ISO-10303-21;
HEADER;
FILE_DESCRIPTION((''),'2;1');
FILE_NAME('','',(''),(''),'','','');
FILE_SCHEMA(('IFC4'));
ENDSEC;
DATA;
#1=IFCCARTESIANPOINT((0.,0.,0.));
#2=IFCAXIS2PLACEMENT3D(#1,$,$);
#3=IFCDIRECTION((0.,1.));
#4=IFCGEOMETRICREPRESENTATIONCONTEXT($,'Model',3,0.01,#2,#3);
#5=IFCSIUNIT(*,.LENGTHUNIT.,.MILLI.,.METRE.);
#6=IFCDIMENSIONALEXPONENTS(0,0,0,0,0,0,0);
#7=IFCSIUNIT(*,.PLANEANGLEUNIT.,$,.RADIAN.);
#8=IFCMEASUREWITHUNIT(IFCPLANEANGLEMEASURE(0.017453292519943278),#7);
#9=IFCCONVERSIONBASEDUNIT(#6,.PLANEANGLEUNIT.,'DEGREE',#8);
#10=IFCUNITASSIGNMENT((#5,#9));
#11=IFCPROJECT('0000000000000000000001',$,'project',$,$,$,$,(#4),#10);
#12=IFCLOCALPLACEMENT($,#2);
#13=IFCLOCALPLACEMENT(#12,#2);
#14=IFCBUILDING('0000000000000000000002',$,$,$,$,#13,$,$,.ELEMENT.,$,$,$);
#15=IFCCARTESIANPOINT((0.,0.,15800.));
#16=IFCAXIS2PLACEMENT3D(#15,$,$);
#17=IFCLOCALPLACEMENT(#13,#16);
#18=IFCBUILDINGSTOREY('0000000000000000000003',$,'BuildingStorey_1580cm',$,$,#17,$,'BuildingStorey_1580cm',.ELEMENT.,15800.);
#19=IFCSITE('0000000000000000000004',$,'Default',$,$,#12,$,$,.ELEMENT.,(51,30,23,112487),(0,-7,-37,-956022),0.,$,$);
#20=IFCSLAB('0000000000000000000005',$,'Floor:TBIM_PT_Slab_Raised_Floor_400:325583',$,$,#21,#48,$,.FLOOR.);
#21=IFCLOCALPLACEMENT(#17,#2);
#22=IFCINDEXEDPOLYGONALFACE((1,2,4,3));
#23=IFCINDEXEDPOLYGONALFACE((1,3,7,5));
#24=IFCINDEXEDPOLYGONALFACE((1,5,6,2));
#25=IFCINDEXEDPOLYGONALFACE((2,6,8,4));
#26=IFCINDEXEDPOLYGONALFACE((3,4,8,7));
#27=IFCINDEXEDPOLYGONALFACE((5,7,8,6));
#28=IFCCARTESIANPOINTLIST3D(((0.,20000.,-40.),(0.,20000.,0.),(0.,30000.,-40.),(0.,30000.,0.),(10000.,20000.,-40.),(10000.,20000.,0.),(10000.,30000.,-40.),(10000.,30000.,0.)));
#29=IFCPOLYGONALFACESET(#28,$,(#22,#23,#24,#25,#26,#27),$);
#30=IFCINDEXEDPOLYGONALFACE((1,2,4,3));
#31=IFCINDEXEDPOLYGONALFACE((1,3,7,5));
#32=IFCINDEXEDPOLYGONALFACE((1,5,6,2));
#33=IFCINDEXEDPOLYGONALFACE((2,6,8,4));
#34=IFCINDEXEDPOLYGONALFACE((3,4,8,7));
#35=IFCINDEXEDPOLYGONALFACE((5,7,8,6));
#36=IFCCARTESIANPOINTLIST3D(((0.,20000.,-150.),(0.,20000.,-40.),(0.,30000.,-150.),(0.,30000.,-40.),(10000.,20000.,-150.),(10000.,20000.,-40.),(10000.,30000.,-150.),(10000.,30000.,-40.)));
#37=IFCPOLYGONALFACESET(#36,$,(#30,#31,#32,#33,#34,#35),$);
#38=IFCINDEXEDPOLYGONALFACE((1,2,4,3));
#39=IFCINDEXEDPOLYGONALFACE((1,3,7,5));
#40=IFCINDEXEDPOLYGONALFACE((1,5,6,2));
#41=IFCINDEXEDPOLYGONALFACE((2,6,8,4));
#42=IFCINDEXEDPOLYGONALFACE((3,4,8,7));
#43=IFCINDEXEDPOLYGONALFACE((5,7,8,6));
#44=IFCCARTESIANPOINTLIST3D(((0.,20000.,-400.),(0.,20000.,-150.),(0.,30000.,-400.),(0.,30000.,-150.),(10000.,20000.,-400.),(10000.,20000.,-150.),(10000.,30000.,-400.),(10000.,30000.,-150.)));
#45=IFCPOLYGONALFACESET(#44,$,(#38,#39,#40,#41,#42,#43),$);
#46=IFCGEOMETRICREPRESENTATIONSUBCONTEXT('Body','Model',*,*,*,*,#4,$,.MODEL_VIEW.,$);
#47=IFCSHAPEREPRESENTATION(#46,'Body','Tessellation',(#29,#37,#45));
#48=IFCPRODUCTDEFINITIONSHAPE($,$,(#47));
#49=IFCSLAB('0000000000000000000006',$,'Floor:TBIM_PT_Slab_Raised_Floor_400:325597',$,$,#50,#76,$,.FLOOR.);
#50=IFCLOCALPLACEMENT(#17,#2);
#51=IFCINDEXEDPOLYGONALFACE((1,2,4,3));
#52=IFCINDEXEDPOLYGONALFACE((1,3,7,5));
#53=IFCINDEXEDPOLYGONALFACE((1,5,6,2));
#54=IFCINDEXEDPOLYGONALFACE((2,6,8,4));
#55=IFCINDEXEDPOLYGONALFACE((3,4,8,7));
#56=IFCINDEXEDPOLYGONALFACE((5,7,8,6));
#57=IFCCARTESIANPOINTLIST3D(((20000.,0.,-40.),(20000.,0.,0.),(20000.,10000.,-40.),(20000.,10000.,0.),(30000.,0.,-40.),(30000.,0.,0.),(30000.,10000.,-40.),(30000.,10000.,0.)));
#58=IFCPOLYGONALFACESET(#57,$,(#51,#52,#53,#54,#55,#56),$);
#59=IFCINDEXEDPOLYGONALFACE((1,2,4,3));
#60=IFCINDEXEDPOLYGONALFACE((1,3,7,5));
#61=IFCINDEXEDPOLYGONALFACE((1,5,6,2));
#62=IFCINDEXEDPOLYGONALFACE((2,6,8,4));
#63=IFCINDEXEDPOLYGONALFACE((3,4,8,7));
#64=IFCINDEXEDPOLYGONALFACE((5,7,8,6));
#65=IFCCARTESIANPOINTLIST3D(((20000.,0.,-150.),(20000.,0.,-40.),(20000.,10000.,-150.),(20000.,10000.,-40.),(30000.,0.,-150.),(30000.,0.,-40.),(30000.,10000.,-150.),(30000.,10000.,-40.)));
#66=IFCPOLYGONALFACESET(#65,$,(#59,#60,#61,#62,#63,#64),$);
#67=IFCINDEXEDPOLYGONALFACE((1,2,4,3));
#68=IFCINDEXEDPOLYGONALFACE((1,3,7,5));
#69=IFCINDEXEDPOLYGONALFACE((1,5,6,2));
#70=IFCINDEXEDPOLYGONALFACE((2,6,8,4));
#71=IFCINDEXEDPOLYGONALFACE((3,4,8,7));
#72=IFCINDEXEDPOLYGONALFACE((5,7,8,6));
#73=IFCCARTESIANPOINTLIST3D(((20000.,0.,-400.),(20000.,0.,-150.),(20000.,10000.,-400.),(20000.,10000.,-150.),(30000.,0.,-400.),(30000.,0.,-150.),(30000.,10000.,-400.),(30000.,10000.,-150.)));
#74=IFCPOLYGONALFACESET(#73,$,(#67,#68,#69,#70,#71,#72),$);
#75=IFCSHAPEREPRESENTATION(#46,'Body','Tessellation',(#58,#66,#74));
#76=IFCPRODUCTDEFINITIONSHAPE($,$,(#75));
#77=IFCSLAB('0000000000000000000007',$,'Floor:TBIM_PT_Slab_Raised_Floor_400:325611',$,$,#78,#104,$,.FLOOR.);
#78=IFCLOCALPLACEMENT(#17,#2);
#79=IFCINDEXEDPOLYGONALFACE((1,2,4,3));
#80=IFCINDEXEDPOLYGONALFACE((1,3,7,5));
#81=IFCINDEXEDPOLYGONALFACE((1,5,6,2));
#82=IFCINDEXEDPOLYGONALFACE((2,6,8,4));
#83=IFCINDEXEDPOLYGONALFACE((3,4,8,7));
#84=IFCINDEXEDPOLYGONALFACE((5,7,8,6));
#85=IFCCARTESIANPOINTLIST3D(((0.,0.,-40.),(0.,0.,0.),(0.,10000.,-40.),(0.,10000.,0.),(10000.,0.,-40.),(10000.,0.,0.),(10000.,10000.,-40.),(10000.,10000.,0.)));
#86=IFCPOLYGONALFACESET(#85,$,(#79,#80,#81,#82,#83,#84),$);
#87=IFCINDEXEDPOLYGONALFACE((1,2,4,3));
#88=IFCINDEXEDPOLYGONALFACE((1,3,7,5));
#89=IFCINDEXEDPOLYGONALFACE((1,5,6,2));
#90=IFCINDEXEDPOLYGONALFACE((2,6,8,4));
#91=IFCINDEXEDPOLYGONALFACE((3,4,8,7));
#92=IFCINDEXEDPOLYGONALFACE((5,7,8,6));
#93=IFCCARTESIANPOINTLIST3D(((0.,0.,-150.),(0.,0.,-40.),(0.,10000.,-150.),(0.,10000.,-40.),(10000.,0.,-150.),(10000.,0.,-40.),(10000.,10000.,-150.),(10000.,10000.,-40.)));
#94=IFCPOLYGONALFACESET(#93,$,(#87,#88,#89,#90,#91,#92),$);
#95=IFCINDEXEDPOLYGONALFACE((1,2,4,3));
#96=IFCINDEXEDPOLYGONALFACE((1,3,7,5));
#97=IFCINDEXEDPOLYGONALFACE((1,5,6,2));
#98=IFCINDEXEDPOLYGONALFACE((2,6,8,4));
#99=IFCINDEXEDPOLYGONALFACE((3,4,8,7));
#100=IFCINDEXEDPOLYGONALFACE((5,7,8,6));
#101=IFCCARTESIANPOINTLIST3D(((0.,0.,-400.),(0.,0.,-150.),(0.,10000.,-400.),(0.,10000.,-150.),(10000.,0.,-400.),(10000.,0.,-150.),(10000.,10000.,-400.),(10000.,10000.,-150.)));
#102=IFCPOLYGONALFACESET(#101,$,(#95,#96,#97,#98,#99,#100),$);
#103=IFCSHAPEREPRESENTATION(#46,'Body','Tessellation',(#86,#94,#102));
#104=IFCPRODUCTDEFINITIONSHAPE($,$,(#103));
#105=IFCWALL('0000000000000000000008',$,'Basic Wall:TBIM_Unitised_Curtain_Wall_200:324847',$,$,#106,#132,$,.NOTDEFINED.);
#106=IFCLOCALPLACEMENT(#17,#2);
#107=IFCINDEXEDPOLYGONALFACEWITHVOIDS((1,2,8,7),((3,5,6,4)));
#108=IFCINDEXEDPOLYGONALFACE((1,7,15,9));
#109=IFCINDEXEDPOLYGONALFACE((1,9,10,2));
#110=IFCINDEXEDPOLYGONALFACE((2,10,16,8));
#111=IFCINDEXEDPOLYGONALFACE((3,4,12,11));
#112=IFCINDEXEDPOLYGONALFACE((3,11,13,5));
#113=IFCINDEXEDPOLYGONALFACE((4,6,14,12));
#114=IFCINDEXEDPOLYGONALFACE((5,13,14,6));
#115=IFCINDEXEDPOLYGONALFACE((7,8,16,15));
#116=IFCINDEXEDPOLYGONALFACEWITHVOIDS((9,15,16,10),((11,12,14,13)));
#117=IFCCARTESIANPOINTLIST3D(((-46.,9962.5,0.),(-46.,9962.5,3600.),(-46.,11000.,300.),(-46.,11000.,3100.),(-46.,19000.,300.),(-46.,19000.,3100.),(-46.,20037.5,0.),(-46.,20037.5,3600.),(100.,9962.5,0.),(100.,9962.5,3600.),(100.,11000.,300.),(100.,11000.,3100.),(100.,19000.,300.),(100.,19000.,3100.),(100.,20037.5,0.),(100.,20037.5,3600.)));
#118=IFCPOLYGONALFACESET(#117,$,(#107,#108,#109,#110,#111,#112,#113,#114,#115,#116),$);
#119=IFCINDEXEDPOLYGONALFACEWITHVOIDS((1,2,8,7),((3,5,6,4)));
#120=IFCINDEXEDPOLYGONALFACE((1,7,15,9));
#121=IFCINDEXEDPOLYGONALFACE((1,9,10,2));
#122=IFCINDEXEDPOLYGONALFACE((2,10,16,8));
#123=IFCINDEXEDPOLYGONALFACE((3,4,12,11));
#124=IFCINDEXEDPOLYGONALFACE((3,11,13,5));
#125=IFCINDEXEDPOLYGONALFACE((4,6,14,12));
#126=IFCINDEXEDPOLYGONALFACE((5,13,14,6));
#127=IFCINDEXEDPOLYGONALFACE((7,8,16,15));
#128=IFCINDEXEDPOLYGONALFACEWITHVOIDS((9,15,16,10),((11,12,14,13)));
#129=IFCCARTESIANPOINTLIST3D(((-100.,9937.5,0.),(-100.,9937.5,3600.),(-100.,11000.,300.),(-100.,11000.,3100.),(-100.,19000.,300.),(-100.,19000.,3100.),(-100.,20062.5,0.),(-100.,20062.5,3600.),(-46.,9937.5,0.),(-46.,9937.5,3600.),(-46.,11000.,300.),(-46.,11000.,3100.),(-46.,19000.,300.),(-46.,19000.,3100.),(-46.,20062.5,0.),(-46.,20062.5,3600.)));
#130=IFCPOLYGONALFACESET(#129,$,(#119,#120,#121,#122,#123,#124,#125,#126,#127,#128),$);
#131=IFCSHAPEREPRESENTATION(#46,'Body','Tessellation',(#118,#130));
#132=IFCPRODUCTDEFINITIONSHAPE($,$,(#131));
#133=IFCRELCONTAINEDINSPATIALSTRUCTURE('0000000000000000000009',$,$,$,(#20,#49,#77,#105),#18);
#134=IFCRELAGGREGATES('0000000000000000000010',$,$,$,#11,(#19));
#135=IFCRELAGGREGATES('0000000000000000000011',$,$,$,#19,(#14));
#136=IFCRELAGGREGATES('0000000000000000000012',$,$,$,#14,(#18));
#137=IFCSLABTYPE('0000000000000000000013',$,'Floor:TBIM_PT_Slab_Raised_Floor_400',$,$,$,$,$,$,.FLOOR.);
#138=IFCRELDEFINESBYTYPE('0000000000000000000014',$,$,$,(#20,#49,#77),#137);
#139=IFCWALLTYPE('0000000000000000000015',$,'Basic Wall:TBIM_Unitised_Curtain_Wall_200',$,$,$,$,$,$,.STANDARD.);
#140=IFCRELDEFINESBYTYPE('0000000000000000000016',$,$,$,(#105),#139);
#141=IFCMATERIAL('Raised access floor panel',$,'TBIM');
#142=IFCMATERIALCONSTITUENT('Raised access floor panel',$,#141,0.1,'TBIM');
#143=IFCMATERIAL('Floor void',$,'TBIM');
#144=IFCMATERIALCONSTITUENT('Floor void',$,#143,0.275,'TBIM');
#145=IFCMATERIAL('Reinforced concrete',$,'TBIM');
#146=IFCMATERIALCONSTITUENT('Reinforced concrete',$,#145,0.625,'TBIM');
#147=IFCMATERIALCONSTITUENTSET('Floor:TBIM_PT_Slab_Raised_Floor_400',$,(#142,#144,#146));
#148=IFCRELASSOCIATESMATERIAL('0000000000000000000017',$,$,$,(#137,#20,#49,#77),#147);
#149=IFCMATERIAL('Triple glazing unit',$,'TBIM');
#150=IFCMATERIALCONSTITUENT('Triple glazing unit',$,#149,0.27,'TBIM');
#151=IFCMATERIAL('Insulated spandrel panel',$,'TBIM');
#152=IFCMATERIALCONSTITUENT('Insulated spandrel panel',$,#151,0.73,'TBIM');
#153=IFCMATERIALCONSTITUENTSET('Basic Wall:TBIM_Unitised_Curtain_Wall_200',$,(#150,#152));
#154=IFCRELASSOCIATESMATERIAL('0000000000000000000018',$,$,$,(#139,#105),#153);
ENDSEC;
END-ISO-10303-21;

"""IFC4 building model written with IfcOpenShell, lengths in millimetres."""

from ifc_helpers import new_model, entity, si_unit, converted_unit, direction, frame, origin, place, context, subcontext, project, spatial, indexed_curve, outline, extrude, material, constituent, constituent_set, type_object, element, save


model = new_model("IFC4")

# Units and contexts
model_context = context("Model", 3, precision=0.01, world=origin(), true_north=direction((0.0, 1.0)))
body_context = subcontext(model_context, "Body", "Model", "MODEL_VIEW")
ifc_project = project(units=[si_unit("LENGTHUNIT", "METRE", prefix="MILLI"), converted_unit("PLANEANGLEUNIT", "DEGREE", entity("IfcPlaneAngleMeasure", 0.017453292519943278), si_unit("PLANEANGLEUNIT", "RADIAN"), dimensions=[0, 0, 0, 0, 0, 0, 0])], contexts=[model_context])

# Site, building, storey
site_placement = place(None, origin())
site = spatial("IfcSite", under=ifc_project, at=site_placement, Name="Default", CompositionType="ELEMENT", RefLatitude=(51, 30, 23, 112487), RefLongitude=(0, -7, -37, -956022), RefElevation=0.0)
building_placement = place(site_placement, origin())
building = spatial("IfcBuilding", under=site, at=building_placement, CompositionType="ELEMENT")
storey_placement = place(building_placement, frame((0.0, 0.0, 15800.0)))
storey = spatial("IfcBuildingStorey", under=building, at=storey_placement, Name="BuildingStorey_1580cm", LongName="BuildingStorey_1580cm", CompositionType="ELEMENT", Elevation=15800.0)

# Slabs
ifc_material_1 = material(Name="Raised access floor panel", Category="TBIM")
ifc_constituent_1 = constituent(ifc_material_1, Name="Raised access floor panel", Category="TBIM", fraction=0.1)
ifc_material_2 = material(Name="Floor void", Category="TBIM")
ifc_constituent_2 = constituent(ifc_material_2, Name="Floor void", Category="TBIM", fraction=0.275)
ifc_material_3 = material(Name="Reinforced concrete", Category="TBIM")
ifc_constituent_3 = constituent(ifc_material_3, Name="Reinforced concrete", Category="TBIM", fraction=0.625)
ifc_constituent_set_1 = constituent_set(constituents=[ifc_constituent_1, ifc_constituent_2, ifc_constituent_3], Name="Floor:TBIM_PT_Slab_Raised_Floor_400")
slab_type = type_object("IfcSlabType", Name="Floor:TBIM_PT_Slab_Raised_Floor_400", PredefinedType="FLOOR", material=ifc_constituent_set_1)
slab_1_placement = place(storey_placement, origin())
element("IfcSlab", 1, at=slab_1_placement, inside=storey, type_object=slab_type, material=ifc_constituent_set_1, Name="Floor:TBIM_PT_Slab_Raised_Floor_400:325583", PredefinedType="FLOOR", context=body_context, shape_type="SweptSolid", body=[
    extrude(outline(indexed_curve([(-5000.0, -5000.0), (5000.0, -5000.0), (5000.0, 5000.0), (-5000.0, 5000.0), (-5000.0, -5000.0)], self_intersect=False)), frame((5000.0, 25000.0, -40.0), z_axis=(0.0, 0.0, 1.0), x_axis=(-1.0, 0.0, 0.0)), (0.0, 0.0, 1.0), 40.0),
    extrude(outline(indexed_curve([(-5000.0, -5000.0), (5000.0, -5000.0), (5000.0, 5000.0), (-5000.0, 5000.0), (-5000.0, -5000.0)], self_intersect=False)), frame((5000.0, 25000.0, -150.0), z_axis=(0.0, 0.0, 1.0), x_axis=(-1.0, 0.0, 0.0)), (0.0, 0.0, 1.0), 110.0),
    extrude(outline(indexed_curve([(-5000.0, -5000.0), (5000.0, -5000.0), (5000.0, 5000.0), (-5000.0, 5000.0), (-5000.0, -5000.0)], self_intersect=False)), frame((5000.0, 25000.0, -400.0), z_axis=(0.0, 0.0, 1.0), x_axis=(-1.0, 0.0, 0.0)), (0.0, 0.0, 1.0), 250.0),
])
slab_2_placement = place(storey_placement, origin())
element("IfcSlab", 2, at=slab_2_placement, inside=storey, type_object=slab_type, material=ifc_constituent_set_1, Name="Floor:TBIM_PT_Slab_Raised_Floor_400:325597", PredefinedType="FLOOR", context=body_context, shape_type="SweptSolid", body=[
    extrude(outline(indexed_curve([(-5000.0, -5000.0), (5000.0, -5000.0), (5000.0, 5000.0), (-5000.0, 5000.0), (-5000.0, -5000.0)], self_intersect=False)), frame((25000.0, 5000.0, -40.0), z_axis=(0.0, 0.0, 1.0), x_axis=(-1.0, 0.0, 0.0)), (0.0, 0.0, 1.0), 40.0),
    extrude(outline(indexed_curve([(-5000.0, -5000.0), (5000.0, -5000.0), (5000.0, 5000.0), (-5000.0, 5000.0), (-5000.0, -5000.0)], self_intersect=False)), frame((25000.0, 5000.0, -150.0), z_axis=(0.0, 0.0, 1.0), x_axis=(-1.0, 0.0, 0.0)), (0.0, 0.0, 1.0), 110.0),
    extrude(outline(indexed_curve([(-5000.0, -5000.0), (5000.0, -5000.0), (5000.0, 5000.0), (-5000.0, 5000.0), (-5000.0, -5000.0)], self_intersect=False)), frame((25000.0, 5000.0, -400.0), z_axis=(0.0, 0.0, 1.0), x_axis=(-1.0, 0.0, 0.0)), (0.0, 0.0, 1.0), 250.0),
])
slab_3_placement = place(storey_placement, origin())
element("IfcSlab", 3, at=slab_3_placement, inside=storey, type_object=slab_type, material=ifc_constituent_set_1, Name="Floor:TBIM_PT_Slab_Raised_Floor_400:325611", PredefinedType="FLOOR", context=body_context, shape_type="SweptSolid", body=[
    extrude(outline(indexed_curve([(-5000.0, -5000.0), (5000.0, -5000.0), (5000.0, 5000.0), (-5000.0, 5000.0), (-5000.0, -5000.0)], self_intersect=False)), frame((5000.0, 5000.0, -40.0), z_axis=(0.0, 0.0, 1.0), x_axis=(-1.0, 0.0, 0.0)), (0.0, 0.0, 1.0), 40.0),
    extrude(outline(indexed_curve([(-5000.0, -5000.0), (5000.0, -5000.0), (5000.0, 5000.0), (-5000.0, 5000.0), (-5000.0, -5000.0)], self_intersect=False)), frame((5000.0, 5000.0, -150.0), z_axis=(0.0, 0.0, 1.0), x_axis=(-1.0, 0.0, 0.0)), (0.0, 0.0, 1.0), 110.0),
    extrude(outline(indexed_curve([(-5000.0, -5000.0), (5000.0, -5000.0), (5000.0, 5000.0), (-5000.0, 5000.0), (-5000.0, -5000.0)], self_intersect=False)), frame((5000.0, 5000.0, -400.0), z_axis=(0.0, 0.0, 1.0), x_axis=(-1.0, 0.0, 0.0)), (0.0, 0.0, 1.0), 250.0),
])

# Wall, opening
ifc_material_4 = material(Name="Triple glazing unit", Category="TBIM")
ifc_constituent_4 = constituent(ifc_material_4, Name="Triple glazing unit", Category="TBIM", fraction=0.27)
ifc_material_5 = material(Name="Insulated spandrel panel", Category="TBIM")
ifc_constituent_5 = constituent(ifc_material_5, Name="Insulated spandrel panel", Category="TBIM", fraction=0.73)
ifc_constituent_set_2 = constituent_set(constituents=[ifc_constituent_4, ifc_constituent_5], Name="Basic Wall:TBIM_Unitised_Curtain_Wall_200")
wall_type = type_object("IfcWallType", Name="Basic Wall:TBIM_Unitised_Curtain_Wall_200", PredefinedType="STANDARD", material=ifc_constituent_set_2)
wall_1_placement = place(storey_placement, frame((0.0, 9937.5, 0.0), z_axis=(0.0, 0.0, 1.0), x_axis=(0.0, 1.0, 0.0)))
wall_1 = element("IfcWall", 4, at=wall_1_placement, inside=storey, type_object=wall_type, material=ifc_constituent_set_2, Name="Basic Wall:TBIM_Unitised_Curtain_Wall_200:324847", PredefinedType="NOTDEFINED", context=body_context, shape_type="SweptSolid", body=[
    extrude(outline(indexed_curve([(-1800.0, -5037.5), (1800.0, -5037.5), (1800.0, 5037.5), (-1800.0, 5037.5), (-1800.0, -5037.5)], self_intersect=False), holes=[indexed_curve([(1300.0, 4000.0), (1300.0, -4000.0), (-1500.0, -4000.0), (-1500.0, 4000.0), (1300.0, 4000.0)], self_intersect=False)]), frame((5062.5, 46.0, 1800.0), z_axis=(0.0, -1.0, 0.0), x_axis=(0.0, 0.0, 1.0)), (0.0, 0.0, 1.0), 146.0),
    extrude(outline(indexed_curve([(-5062.5, -1800.0), (5062.5, -1800.0), (5062.5, 1800.0), (-5062.5, 1800.0), (-5062.5, -1800.0)], self_intersect=False), holes=[indexed_curve([(-4000.0, 1300.0), (4000.0, 1300.0), (4000.0, -1500.0), (-4000.0, -1500.0), (-4000.0, 1300.0)], self_intersect=False)]), frame((5062.5, 100.0, 1800.0), z_axis=(0.0, -1.0, 0.0), x_axis=(1.0, 0.0, 0.0)), (0.0, 0.0, 1.0), 54.0),
])
opening_1_placement = place(wall_1_placement, frame((1062.5, -100.0, 300.0)))
element("IfcOpeningElement", 5, at=opening_1_placement, cuts=wall_1, PredefinedType="OPENING", context=body_context, shape_type="SweptSolid", body=[
    extrude(outline(indexed_curve([(2800.0, 0.0), (2800.0, 8000.0), (0.0, 8000.0), (0.0, 0.0), (2800.0, 0.0)], self_intersect=False)), frame((0.0, 0.0, 0.0), z_axis=(0.0, 1.0, 0.0), x_axis=(0.0, 0.0, 1.0)), (0.0, 0.0, 1.0), 200.0),
])

save(model, "model.ifc")
